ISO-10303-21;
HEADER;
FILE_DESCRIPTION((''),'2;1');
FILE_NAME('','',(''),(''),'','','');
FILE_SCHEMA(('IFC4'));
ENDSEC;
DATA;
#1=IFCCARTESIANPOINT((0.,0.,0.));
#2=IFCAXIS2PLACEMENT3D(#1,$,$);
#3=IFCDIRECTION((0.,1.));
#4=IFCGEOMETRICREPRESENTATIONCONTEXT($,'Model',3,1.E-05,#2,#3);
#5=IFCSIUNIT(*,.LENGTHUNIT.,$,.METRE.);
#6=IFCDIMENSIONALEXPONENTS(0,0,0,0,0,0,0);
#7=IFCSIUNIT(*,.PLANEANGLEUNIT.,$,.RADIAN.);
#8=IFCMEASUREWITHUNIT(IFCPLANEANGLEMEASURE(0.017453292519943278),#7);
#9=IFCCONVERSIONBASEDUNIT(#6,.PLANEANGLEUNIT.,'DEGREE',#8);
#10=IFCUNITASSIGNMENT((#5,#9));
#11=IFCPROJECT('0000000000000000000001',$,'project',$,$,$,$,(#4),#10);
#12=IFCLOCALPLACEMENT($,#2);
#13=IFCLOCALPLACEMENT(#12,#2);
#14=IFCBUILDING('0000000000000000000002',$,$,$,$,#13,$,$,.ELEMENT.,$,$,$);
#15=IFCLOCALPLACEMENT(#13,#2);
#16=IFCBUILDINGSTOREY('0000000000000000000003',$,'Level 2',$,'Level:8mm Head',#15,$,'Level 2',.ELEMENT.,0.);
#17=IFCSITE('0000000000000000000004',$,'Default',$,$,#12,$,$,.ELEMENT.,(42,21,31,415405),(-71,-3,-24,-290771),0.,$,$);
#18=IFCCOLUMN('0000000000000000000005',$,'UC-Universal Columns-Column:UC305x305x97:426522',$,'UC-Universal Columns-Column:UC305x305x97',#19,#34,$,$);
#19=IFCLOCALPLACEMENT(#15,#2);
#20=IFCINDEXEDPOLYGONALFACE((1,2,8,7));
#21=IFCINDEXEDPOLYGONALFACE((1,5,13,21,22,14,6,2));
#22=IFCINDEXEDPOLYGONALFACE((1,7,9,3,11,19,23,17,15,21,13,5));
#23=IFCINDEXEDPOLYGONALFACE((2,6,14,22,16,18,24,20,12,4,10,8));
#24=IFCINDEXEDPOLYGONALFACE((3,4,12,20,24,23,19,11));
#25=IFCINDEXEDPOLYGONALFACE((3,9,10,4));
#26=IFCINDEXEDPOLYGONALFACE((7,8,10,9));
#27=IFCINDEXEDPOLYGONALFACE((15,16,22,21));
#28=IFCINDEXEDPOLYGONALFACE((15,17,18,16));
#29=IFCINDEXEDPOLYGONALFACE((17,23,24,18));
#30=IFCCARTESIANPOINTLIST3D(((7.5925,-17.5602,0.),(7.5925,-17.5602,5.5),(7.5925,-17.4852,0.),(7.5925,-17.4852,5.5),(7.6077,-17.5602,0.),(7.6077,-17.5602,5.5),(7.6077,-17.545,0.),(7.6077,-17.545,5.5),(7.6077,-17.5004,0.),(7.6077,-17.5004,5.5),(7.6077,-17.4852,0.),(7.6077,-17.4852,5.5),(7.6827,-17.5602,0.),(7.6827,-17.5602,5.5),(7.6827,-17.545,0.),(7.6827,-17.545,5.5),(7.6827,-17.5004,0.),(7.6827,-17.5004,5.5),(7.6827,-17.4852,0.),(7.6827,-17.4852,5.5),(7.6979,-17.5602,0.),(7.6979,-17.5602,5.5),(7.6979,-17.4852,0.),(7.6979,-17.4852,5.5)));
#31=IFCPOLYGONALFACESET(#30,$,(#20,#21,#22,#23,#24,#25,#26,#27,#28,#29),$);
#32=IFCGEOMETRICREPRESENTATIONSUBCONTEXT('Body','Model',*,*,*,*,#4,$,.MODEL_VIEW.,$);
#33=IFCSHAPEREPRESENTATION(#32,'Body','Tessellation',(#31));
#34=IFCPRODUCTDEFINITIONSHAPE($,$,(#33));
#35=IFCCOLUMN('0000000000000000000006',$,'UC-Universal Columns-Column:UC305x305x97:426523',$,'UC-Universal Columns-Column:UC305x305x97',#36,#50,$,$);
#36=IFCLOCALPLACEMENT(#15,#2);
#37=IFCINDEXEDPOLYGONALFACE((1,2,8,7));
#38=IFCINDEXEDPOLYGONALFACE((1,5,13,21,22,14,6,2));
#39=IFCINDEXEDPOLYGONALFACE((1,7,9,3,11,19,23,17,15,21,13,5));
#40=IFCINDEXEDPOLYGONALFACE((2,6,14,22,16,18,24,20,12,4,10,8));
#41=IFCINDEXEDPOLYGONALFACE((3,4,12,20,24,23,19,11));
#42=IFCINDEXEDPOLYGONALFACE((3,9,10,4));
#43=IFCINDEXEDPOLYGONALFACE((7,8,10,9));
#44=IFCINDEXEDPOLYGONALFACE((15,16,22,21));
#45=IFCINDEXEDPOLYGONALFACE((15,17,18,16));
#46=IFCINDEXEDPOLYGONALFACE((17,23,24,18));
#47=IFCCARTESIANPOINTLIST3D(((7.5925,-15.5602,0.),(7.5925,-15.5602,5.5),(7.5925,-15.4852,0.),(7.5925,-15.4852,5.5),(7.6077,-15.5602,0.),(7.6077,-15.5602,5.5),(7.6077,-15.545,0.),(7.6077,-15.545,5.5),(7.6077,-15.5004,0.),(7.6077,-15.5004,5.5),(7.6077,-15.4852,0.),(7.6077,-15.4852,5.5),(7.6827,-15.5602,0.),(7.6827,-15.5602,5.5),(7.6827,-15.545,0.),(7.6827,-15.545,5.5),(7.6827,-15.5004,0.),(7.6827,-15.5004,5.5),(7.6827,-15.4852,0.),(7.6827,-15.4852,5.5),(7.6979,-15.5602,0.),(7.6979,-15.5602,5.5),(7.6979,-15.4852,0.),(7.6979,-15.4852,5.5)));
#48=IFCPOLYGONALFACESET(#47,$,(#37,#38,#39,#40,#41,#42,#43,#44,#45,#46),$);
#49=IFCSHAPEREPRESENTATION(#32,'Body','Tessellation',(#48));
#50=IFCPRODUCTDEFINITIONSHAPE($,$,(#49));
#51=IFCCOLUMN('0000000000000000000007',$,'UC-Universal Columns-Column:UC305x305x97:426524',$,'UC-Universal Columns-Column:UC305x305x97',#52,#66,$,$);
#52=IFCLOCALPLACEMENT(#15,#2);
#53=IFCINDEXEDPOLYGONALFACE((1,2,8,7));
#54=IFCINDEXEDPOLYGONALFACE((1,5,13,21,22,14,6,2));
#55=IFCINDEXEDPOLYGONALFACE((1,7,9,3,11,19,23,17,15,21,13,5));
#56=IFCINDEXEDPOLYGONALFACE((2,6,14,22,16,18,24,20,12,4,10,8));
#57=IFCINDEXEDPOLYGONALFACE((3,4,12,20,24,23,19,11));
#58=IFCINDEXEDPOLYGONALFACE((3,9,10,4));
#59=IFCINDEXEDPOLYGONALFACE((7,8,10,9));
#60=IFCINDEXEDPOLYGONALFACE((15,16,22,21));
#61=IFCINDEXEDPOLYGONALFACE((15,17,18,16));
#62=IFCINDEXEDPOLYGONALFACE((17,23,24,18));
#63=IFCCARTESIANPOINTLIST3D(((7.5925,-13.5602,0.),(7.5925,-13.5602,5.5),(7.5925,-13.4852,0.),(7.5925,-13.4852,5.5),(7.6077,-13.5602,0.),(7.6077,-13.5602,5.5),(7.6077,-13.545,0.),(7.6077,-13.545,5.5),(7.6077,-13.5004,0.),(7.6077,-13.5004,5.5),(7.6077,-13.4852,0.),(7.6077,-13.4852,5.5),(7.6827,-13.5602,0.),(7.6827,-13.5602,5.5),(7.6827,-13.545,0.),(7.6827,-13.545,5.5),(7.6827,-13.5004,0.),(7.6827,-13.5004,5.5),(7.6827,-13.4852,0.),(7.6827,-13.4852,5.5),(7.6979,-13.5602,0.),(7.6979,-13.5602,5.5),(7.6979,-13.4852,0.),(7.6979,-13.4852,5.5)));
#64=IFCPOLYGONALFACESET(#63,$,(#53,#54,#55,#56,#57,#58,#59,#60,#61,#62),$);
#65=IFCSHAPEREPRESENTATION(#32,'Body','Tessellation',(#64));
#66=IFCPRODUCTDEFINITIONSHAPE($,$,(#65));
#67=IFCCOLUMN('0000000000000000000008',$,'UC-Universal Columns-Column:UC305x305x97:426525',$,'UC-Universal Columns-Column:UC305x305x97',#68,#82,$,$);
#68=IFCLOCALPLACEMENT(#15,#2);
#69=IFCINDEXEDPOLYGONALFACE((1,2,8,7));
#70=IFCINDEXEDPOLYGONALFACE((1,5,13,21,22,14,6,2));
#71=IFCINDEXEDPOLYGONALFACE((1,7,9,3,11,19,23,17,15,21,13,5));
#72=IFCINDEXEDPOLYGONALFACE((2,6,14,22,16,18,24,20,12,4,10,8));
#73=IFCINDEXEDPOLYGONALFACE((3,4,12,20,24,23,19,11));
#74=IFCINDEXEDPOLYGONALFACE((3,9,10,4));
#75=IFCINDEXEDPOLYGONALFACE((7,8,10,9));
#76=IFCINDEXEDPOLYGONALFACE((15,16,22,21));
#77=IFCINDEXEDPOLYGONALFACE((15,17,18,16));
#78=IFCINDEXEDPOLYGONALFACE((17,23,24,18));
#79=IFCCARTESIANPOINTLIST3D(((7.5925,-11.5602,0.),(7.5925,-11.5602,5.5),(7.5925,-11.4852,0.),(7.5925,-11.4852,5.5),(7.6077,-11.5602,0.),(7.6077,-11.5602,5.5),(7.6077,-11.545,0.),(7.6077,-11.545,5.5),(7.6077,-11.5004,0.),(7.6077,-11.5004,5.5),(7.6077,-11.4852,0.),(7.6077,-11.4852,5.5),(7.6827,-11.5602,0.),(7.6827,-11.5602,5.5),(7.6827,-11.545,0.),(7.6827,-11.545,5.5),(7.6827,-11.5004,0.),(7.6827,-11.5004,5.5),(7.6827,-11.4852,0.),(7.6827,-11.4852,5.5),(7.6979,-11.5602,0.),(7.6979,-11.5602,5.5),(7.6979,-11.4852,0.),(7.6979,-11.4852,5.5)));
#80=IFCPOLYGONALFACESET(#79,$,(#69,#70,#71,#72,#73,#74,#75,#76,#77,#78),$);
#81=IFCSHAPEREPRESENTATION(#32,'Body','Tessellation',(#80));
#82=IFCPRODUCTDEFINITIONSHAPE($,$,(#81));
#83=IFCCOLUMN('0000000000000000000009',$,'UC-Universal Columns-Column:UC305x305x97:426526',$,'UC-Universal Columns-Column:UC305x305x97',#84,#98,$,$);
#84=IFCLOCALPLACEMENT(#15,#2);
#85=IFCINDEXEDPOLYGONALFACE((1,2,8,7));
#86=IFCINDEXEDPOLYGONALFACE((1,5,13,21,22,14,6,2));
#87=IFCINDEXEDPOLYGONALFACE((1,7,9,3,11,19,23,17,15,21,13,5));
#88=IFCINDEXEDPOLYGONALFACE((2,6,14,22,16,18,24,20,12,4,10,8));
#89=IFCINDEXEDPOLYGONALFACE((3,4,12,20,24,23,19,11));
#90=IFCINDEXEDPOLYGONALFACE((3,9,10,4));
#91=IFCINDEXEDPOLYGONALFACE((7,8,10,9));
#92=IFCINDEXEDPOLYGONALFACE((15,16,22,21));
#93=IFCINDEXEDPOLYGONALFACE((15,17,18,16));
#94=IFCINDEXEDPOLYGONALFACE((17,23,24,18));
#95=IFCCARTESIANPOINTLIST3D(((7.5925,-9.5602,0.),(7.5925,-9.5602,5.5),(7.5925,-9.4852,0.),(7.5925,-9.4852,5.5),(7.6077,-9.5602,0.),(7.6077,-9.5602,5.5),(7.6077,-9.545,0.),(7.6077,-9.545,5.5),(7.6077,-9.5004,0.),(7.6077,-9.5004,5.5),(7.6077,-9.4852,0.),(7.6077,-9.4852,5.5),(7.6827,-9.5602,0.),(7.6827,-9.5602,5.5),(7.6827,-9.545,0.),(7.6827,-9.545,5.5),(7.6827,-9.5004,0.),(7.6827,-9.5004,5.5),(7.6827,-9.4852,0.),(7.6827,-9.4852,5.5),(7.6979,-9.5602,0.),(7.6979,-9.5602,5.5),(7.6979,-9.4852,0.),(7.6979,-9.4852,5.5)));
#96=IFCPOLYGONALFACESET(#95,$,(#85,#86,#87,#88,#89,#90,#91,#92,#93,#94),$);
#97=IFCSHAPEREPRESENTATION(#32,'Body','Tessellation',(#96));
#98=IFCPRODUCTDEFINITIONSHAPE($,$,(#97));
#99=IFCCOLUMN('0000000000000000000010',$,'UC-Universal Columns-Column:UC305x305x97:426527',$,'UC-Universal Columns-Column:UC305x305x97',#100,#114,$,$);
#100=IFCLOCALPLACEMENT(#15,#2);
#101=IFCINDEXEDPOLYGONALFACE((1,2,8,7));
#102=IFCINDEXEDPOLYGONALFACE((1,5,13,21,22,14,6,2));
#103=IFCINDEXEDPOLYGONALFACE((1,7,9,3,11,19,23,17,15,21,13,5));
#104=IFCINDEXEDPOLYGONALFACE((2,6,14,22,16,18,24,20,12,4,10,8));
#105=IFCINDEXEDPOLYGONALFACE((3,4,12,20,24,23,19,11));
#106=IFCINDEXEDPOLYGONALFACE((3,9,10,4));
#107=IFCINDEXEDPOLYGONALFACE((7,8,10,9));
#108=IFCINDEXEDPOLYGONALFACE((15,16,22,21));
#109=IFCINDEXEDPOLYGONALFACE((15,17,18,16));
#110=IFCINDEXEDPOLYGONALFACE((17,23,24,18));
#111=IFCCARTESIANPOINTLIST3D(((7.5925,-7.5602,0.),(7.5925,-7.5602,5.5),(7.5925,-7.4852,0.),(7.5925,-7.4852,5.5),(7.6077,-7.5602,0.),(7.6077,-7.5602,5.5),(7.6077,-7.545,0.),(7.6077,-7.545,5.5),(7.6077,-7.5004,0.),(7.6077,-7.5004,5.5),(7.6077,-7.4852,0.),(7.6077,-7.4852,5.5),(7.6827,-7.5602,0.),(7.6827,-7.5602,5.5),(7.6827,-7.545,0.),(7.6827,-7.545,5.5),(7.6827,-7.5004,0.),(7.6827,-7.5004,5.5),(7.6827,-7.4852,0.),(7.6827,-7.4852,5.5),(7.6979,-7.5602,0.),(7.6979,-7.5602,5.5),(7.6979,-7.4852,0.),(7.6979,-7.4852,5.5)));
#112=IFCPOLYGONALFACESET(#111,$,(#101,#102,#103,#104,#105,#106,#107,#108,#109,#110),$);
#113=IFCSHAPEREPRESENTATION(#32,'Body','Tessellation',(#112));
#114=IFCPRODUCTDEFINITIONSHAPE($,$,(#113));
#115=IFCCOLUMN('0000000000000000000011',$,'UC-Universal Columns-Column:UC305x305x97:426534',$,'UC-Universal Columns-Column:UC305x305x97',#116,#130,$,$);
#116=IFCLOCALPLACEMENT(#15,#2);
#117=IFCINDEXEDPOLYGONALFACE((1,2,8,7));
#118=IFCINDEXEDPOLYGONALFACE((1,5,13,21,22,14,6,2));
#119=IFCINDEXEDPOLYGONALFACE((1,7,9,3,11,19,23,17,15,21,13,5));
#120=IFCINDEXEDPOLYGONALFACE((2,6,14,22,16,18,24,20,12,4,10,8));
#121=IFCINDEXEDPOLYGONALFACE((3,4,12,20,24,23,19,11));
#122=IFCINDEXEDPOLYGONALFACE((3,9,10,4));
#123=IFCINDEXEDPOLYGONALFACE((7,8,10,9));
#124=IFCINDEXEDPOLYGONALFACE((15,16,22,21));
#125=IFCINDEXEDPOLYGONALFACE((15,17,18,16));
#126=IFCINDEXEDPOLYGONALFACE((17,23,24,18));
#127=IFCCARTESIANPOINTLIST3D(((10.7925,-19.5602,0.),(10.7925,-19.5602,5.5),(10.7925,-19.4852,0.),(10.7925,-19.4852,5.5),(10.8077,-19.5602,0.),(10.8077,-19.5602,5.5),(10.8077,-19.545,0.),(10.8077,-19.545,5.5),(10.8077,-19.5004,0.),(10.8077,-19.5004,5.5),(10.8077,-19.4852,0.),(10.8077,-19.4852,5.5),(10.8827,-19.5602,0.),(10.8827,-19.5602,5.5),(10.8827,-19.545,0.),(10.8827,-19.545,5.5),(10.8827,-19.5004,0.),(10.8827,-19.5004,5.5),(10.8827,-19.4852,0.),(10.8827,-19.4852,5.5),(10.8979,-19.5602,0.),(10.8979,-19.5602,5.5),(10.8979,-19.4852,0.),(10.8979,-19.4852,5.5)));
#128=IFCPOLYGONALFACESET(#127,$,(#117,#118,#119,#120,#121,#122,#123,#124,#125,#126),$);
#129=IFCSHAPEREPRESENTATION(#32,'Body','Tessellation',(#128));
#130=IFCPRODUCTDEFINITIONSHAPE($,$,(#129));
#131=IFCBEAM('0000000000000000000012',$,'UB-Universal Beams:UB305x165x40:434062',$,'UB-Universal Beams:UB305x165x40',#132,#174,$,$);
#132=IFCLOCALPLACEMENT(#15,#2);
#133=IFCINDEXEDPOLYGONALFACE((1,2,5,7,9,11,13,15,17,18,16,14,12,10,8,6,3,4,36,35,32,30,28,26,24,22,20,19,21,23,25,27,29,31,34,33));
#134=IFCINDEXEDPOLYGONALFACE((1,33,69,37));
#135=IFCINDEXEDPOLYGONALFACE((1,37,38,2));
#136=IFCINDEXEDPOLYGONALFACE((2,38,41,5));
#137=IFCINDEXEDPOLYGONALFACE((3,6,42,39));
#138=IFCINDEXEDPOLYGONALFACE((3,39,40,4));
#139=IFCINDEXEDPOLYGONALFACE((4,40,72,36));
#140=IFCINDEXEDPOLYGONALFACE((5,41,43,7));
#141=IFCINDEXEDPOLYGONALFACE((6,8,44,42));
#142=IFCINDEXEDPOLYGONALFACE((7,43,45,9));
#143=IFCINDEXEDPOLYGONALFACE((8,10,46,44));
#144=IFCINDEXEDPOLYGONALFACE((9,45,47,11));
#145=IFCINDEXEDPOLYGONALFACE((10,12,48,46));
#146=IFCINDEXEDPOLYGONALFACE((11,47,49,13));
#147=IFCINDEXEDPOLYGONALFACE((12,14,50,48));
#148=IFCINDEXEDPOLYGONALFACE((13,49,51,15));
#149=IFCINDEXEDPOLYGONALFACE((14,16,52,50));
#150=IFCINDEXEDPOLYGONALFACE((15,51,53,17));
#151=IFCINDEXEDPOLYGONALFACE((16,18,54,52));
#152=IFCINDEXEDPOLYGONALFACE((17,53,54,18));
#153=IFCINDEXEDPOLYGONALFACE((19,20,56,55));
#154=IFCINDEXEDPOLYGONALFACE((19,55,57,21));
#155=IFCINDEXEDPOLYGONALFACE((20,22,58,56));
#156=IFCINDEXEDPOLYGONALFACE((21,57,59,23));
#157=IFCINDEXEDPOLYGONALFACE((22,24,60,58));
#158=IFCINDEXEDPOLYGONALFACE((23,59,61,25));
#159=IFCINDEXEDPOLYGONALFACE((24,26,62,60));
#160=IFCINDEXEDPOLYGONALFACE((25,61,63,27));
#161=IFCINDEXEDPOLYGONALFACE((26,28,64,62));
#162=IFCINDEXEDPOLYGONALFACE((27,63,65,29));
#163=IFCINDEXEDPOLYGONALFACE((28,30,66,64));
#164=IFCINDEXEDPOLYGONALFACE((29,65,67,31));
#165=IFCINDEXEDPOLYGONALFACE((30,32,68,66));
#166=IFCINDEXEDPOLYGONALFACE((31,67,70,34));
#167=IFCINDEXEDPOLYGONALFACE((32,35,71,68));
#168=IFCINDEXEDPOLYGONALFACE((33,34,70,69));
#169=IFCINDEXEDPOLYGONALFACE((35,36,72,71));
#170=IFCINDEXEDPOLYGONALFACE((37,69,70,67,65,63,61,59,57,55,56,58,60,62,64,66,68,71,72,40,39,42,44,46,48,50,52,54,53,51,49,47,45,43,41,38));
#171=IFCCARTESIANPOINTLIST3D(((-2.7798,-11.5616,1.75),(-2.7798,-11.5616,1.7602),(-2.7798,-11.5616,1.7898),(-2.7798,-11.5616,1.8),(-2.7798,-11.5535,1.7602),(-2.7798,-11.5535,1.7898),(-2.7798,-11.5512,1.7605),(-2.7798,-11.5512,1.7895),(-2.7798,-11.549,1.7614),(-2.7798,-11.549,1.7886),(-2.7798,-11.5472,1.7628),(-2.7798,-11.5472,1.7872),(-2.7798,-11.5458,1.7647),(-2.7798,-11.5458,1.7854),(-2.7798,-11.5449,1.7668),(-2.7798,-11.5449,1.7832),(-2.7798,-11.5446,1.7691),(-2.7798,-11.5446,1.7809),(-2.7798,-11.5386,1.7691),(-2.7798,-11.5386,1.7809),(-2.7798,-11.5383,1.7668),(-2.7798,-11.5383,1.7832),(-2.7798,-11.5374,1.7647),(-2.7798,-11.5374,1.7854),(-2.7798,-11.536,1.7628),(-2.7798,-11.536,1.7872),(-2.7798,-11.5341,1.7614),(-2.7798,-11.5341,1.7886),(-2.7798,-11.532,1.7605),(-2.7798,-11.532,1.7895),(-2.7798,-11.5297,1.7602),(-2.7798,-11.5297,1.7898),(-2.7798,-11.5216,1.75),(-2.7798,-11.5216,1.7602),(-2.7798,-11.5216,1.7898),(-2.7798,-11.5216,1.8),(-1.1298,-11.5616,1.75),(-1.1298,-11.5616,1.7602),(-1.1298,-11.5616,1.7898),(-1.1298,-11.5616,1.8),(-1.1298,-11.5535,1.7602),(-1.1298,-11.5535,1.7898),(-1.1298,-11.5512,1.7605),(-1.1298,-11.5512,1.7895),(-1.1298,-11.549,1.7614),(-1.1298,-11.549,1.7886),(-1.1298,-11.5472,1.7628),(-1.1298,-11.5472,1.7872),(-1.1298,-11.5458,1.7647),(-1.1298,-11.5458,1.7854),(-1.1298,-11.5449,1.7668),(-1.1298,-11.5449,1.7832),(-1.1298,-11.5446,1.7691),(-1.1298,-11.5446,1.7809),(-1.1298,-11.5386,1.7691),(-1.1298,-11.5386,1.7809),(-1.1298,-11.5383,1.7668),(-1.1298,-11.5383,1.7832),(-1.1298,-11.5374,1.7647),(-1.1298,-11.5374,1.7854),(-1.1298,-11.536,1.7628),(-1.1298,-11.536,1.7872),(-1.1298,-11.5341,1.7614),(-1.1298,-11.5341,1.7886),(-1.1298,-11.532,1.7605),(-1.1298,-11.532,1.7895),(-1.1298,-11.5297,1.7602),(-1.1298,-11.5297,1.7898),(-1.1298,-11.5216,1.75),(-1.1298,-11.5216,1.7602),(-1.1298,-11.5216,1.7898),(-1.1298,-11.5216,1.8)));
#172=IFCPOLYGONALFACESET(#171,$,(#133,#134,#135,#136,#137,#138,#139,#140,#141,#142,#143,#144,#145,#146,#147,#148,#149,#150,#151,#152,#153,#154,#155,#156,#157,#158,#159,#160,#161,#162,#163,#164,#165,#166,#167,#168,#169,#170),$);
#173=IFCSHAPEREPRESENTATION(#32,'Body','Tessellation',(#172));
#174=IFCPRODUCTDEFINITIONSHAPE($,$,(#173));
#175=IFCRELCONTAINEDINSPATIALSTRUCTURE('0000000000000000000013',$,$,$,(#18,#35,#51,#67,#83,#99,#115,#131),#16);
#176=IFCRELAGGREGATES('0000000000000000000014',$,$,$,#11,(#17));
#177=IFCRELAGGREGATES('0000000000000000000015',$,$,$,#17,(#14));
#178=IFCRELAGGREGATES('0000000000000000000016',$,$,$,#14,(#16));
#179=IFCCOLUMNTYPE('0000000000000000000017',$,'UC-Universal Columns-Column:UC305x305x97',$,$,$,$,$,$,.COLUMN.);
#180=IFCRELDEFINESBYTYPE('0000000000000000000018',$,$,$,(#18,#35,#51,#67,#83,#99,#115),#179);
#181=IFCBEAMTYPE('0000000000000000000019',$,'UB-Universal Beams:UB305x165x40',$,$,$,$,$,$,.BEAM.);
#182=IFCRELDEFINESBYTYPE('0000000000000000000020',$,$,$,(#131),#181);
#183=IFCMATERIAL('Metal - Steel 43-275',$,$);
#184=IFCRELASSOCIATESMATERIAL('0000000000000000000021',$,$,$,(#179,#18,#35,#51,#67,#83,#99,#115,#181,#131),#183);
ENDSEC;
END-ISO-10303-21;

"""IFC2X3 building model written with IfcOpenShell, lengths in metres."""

from ifc_helpers import new_model, entity, si_unit, converted_unit, direction, frame, frame_2d, origin, place, context, subcontext, project, spatial, polyline, circle_curve, parameter, trimmed, segment, composite_curve, i_section, outline, extrude, source, transform, mapped, material, type_object, type_shapes, element, save


model = new_model("IFC2X3")

# Units and contexts
model_context = context("Model", 3, precision=1e-05, world=origin(), true_north=direction((0.0, 1.0)))
body_context = subcontext(model_context, "Body", "Model", "MODEL_VIEW")
ifc_project = project(units=[si_unit("LENGTHUNIT", "METRE"), converted_unit("PLANEANGLEUNIT", "DEGREE", entity("IfcPlaneAngleMeasure", 0.017453292519943278), si_unit("PLANEANGLEUNIT", "RADIAN"), dimensions=[0, 0, 0, 0, 0, 0, 0])], contexts=[model_context])

# Site, building, storey
site_placement = place(None, origin())
site = spatial("IfcSite", under=ifc_project, at=site_placement, Name="Default", CompositionType="ELEMENT", RefLatitude=(42, 21, 31, 415405), RefLongitude=(-71, -3, -24, -290771), RefElevation=0.0)
building_placement = place(site_placement, origin())
building = spatial("IfcBuilding", under=site, at=building_placement, CompositionType="ELEMENT")
storey_placement = place(building_placement, origin())
storey = spatial("IfcBuildingStorey", under=building, at=storey_placement, Name="Level 2", ObjectType="Level:8mm Head", LongName="Level 2", CompositionType="ELEMENT", Elevation=0.0)

# Columns
ifc_material = material(Name="Metal - Steel 43-275")
column_type = type_object("IfcColumnType", Name="UC-Universal Columns-Column:UC305x305x97", PredefinedType="COLUMN", material=ifc_material)
shared_shape = source(origin(), body_context, "Body", "SweptSolid", [
    extrude(outline(composite_curve([segment(polyline([(-0.0375, -0.0375), (0.0375, -0.0375)]), True, "CONTINUOUS"), segment(polyline([(0.0375, -0.0375), (0.0527, -0.0375)]), True, "CONTINUOUS"), segment(trimmed(circle_curve(frame_2d((0.0527, -0.0223), x_axis=(-1.0, 0.0)), 0.0152), [parameter(0.0)], [parameter(90.0)], True, "PARAMETER"), False, "CONTINUOUS"), segment(polyline([(0.0375, -0.0223), (0.0375, 0.0223)]), True, "CONTINUOUS"), segment(trimmed(circle_curve(frame_2d((0.0527, 0.0223), x_axis=(-1.0, 0.0)), 0.0152), [parameter(270.0)], [parameter(0.0)], True, "PARAMETER"), False, "CONTINUOUS"), segment(polyline([(0.0527, 0.0375), (0.0375, 0.0375)]), True, "CONTINUOUS"), segment(polyline([(0.0375, 0.0375), (-0.0375, 0.0375)]), True, "CONTINUOUS"), segment(polyline([(-0.0375, 0.0375), (-0.0527, 0.0375)]), True, "CONTINUOUS"), segment(trimmed(circle_curve(frame_2d((-0.0527, 0.0223), x_axis=(-1.0, 0.0)), 0.0152), [parameter(180.0)], [parameter(270.0)], True, "PARAMETER"), False, "CONTINUOUS"), segment(polyline([(-0.0375, 0.0223), (-0.0375, -0.0223)]), True, "CONTINUOUS"), segment(trimmed(circle_curve(frame_2d((-0.0527, -0.0223), x_axis=(-1.0, 0.0)), 0.0152), [parameter(90.0)], [parameter(180.0)], True, "PARAMETER"), False, "CONTINUOUS"), segment(polyline([(-0.0527, -0.0375), (-0.0375, -0.0375)]), True, "CONTINUOUS")], self_intersect=False)), frame((0.0, 0.0, 0.0), z_axis=(0.0, 0.0, 1.0), x_axis=(-1.0, 0.0, 0.0)), (0.0, 0.0, 1.0), 5.5),
])
type_shapes(column_type, [shared_shape])
for number, where, z_axis, x_axis, name in (
    (1, (7.6452, -17.5227, 0.0), (0.0, 0.0, 1.0), (-1.0, 0.0, 0.0), "UC-Universal Columns-Column:UC305x305x97:426522"),
    (2, (7.6452, -15.5227, 0.0), (0.0, 0.0, 1.0), (-1.0, 0.0, 0.0), "UC-Universal Columns-Column:UC305x305x97:426523"),
    (3, (7.6452, -13.5227, 0.0), (0.0, 0.0, 1.0), (-1.0, 0.0, 0.0), "UC-Universal Columns-Column:UC305x305x97:426524"),
    (4, (7.6452, -11.5227, 0.0), (0.0, 0.0, 1.0), (-1.0, 0.0, 0.0), "UC-Universal Columns-Column:UC305x305x97:426525"),
    (5, (7.6452, -9.5227, 0.0), (0.0, 0.0, 1.0), (-1.0, 0.0, 0.0), "UC-Universal Columns-Column:UC305x305x97:426526"),
    (6, (7.6452, -7.5227, 0.0), (0.0, 0.0, 1.0), (-1.0, 0.0, 0.0), "UC-Universal Columns-Column:UC305x305x97:426527"),
    (7, (10.8452, -19.5227, 0.0), (0.0, 0.0, 1.0), (-1.0, 0.0, 0.0), "UC-Universal Columns-Column:UC305x305x97:426534"),
):
    element("IfcColumn", number, at=place(storey_placement, frame(where, z_axis=z_axis, x_axis=x_axis)), inside=storey, type_object=column_type, material=ifc_material, Name=name, ObjectType="UC-Universal Columns-Column:UC305x305x97", context=body_context, shape_type="MappedRepresentation", body=[
        mapped(shared_shape, transform((0.0, 0.0, 0.0), scale=1.0)),
    ])

# Beam
beam_type = type_object("IfcBeamType", Name="UB-Universal Beams:UB305x165x40", PredefinedType="BEAM", material=ifc_material)
beam_1_placement = place(storey_placement, frame((-2.7798, -11.5416, 1.8)))
element("IfcBeam", 8, at=beam_1_placement, inside=storey, type_object=beam_type, material=ifc_material, Name="UB-Universal Beams:UB305x165x40:434062", ObjectType="UB-Universal Beams:UB305x165x40", context=body_context, shape_type="SweptSolid", body=[
    extrude(i_section(OverallWidth=0.04, OverallDepth=0.05, WebThickness=0.006, FlangeThickness=0.0102, FilletRadius=0.0089, at=frame_2d((0.0, 0.0), x_axis=(0.0, 1.0))), frame((0.0, 0.0, -0.025), z_axis=(1.0, 0.0, 0.0), x_axis=(0.0, 0.0, -1.0)), (0.0, 0.0, 1.0), 1.65),
])

save(model, "model.ifc")
